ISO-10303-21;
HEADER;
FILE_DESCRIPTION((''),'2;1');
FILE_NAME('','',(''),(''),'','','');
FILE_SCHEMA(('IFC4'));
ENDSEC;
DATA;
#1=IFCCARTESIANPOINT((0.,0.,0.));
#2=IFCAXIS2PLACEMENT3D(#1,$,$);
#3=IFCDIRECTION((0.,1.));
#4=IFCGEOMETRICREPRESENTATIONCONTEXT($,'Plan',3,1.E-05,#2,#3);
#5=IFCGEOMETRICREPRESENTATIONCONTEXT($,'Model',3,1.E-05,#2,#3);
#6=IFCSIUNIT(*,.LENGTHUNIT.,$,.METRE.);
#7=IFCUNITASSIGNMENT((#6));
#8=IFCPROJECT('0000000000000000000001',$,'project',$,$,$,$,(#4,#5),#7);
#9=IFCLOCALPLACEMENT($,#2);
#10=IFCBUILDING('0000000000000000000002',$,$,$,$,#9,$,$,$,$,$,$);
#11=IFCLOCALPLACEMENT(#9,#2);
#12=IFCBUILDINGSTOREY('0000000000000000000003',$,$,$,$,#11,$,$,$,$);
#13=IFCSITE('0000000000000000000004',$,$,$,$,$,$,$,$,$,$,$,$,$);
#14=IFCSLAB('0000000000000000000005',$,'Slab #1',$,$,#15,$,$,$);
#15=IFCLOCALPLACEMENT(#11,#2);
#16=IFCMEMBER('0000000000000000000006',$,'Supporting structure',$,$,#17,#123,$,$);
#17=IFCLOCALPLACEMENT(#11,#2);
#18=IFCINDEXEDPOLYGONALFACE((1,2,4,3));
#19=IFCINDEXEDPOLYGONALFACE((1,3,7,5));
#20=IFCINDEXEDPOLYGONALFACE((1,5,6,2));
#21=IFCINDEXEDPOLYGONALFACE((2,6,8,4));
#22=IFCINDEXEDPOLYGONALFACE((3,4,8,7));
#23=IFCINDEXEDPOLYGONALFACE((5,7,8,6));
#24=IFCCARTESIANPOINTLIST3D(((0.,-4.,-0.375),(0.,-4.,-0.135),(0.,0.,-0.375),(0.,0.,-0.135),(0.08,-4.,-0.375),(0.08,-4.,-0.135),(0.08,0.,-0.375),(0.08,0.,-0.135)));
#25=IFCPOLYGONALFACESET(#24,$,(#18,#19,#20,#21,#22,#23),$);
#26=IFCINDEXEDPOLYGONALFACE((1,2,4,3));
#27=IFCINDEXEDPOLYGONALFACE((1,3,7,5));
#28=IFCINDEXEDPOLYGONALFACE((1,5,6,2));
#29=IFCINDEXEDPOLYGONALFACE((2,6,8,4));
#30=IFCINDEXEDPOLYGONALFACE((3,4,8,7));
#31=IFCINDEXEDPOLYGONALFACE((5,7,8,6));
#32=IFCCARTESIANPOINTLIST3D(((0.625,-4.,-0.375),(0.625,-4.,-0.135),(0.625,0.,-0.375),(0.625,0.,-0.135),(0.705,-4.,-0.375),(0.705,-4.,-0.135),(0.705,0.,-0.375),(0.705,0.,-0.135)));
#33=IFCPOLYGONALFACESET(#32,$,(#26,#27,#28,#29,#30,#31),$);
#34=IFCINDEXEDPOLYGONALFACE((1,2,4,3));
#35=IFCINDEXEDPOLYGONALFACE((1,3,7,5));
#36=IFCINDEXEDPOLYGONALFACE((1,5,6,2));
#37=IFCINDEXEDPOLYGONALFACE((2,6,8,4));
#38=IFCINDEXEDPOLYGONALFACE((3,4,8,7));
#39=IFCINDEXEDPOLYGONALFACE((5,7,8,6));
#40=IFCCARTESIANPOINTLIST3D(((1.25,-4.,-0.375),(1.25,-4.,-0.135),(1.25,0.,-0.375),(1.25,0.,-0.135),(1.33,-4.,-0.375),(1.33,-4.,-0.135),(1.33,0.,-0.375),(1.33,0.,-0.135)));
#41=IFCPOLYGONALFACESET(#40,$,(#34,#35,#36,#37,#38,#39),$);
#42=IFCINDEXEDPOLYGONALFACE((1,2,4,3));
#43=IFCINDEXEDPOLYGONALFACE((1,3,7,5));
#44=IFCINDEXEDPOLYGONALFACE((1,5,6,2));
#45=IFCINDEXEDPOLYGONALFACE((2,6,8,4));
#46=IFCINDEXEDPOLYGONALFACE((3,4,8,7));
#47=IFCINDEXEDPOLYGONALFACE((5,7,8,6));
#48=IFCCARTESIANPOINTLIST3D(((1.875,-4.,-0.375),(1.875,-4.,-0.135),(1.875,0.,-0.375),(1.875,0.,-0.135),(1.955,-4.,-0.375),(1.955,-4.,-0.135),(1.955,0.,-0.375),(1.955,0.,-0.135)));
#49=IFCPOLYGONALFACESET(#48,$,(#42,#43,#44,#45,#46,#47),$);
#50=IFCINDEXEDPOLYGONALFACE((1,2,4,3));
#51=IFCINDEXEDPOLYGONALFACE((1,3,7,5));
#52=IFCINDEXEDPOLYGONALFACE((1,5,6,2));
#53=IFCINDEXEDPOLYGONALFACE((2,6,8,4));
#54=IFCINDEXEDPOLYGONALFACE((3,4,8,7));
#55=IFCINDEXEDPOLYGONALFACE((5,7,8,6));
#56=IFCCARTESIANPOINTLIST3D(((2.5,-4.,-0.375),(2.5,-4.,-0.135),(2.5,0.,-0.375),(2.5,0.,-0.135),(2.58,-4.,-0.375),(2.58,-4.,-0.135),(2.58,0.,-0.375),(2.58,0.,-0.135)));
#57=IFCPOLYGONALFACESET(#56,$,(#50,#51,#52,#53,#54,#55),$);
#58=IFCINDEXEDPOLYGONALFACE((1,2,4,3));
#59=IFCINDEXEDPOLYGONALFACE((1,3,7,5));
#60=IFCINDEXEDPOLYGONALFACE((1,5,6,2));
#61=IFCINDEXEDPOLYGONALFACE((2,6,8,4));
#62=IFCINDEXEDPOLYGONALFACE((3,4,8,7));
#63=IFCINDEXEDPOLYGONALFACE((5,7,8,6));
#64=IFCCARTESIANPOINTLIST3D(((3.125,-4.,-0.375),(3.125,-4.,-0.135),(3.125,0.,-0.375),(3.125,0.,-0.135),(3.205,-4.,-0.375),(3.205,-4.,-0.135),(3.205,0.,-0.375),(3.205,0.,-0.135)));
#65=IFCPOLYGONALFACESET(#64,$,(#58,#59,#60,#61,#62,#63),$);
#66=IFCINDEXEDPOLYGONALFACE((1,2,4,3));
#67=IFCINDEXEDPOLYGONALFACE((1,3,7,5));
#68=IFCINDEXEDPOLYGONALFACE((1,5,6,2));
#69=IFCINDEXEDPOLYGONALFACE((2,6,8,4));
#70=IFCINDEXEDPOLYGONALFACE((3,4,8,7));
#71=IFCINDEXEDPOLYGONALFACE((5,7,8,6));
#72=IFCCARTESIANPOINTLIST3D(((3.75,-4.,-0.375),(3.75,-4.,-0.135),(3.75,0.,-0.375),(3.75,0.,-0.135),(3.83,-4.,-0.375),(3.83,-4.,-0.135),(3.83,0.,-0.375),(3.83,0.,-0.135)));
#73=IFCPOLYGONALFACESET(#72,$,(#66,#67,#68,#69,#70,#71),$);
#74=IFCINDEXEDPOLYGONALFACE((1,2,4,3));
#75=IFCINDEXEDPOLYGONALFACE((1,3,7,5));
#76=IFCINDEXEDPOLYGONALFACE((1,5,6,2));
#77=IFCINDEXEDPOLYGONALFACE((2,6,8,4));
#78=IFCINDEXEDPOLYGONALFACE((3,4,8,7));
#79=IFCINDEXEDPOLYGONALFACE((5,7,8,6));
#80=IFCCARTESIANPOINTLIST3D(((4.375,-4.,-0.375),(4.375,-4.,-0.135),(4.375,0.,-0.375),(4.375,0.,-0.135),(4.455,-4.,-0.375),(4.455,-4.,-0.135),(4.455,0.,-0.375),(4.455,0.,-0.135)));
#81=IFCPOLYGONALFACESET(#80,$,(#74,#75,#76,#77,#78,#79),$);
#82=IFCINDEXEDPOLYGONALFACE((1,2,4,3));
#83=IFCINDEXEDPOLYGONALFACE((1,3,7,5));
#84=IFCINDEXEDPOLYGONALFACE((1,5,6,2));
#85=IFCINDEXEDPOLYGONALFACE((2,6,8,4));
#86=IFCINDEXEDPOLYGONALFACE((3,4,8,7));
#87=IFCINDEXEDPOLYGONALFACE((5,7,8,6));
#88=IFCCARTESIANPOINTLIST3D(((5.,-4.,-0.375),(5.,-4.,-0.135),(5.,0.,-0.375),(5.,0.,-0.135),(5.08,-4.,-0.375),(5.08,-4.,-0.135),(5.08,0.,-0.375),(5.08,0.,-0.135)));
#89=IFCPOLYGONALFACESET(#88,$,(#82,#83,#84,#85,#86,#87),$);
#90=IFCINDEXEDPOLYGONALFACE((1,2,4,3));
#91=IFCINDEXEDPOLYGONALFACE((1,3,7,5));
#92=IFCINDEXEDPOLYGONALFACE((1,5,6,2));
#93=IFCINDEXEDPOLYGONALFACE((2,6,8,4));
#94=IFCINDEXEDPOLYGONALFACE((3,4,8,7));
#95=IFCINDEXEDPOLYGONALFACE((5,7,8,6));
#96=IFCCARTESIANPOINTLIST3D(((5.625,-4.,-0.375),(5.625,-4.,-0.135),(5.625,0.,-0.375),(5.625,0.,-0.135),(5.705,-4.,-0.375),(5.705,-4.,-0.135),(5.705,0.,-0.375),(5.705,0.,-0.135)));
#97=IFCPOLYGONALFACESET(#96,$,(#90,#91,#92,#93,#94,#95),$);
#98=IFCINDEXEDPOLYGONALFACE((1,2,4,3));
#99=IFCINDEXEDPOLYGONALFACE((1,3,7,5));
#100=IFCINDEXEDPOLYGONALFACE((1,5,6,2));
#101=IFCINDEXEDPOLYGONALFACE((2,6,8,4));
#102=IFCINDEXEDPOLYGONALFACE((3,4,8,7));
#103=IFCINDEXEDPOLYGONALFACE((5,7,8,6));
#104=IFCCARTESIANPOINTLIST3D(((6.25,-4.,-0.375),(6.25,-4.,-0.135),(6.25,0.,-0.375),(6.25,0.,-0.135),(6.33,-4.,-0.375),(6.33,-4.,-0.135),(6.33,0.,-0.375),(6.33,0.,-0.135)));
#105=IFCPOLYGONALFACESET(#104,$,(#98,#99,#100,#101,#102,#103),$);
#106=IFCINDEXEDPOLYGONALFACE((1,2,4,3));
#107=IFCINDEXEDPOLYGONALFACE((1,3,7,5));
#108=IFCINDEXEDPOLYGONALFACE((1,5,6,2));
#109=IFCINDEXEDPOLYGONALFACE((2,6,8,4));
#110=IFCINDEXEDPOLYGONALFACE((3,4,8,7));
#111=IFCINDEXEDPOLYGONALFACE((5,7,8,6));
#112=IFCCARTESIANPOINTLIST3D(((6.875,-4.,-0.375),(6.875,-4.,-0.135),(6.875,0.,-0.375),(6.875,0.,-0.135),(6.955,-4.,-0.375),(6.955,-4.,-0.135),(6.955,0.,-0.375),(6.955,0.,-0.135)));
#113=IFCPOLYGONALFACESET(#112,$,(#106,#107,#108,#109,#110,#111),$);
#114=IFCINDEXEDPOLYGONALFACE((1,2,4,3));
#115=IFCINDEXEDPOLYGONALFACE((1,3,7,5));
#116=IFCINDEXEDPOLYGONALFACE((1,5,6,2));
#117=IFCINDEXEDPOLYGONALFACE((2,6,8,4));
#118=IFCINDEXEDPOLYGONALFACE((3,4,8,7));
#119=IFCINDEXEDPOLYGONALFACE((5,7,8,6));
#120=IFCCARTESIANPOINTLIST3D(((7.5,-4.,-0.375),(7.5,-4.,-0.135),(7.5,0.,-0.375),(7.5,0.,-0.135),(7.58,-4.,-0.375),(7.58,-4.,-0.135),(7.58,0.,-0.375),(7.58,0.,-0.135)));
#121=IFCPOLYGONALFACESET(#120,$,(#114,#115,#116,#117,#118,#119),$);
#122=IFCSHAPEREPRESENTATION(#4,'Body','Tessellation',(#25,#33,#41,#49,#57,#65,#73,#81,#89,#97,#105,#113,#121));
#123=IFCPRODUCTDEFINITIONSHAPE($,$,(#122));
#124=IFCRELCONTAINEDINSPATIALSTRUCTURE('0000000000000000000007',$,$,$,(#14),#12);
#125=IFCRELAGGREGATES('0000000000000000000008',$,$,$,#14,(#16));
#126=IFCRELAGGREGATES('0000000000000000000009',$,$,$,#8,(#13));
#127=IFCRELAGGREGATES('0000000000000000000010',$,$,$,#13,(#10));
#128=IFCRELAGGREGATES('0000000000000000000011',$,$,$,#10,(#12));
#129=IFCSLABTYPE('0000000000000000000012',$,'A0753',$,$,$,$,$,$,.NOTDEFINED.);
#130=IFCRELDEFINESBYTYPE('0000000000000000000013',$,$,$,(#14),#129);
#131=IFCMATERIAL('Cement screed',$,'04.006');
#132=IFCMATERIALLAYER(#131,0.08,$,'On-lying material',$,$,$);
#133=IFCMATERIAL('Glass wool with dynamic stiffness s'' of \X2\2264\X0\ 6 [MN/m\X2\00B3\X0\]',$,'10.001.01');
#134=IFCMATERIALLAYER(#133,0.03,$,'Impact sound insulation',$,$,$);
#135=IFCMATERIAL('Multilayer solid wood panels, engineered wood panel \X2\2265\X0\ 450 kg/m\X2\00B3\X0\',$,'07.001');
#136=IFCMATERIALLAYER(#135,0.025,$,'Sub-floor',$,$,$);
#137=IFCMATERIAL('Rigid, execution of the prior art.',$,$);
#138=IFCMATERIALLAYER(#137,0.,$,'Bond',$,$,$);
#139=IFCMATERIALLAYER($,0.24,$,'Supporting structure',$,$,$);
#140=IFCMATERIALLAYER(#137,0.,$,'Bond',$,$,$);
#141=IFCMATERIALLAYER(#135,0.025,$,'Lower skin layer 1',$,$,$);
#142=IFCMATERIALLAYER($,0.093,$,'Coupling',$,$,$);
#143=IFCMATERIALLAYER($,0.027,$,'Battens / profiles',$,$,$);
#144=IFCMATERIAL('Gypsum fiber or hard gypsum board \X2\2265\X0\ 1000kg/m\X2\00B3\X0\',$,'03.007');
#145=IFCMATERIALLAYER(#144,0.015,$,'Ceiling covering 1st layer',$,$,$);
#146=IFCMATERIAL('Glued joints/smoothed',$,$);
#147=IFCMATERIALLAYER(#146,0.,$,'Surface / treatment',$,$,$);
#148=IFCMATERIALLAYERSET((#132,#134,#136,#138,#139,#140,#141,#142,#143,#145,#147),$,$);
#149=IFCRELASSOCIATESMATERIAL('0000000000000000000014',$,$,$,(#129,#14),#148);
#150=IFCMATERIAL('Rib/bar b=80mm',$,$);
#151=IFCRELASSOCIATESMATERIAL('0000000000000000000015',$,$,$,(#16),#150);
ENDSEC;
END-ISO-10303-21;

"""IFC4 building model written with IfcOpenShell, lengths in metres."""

from ifc_helpers import new_model, si_unit, direction, frame, frame_2d, origin, place, context, project, spatial, rectangle, extrude, material, layer, layer_set, type_object, element, aggregate, save


model = new_model("IFC4")

# Units and contexts
plan_context = context("Plan", 3, precision=1e-05, world=origin(), true_north=direction((0.0, 1.0)))
model_context = context("Model", 3, precision=1e-05, world=origin(), true_north=direction((0.0, 1.0)))
ifc_project = project(units=[si_unit("LENGTHUNIT", "METRE")], contexts=[plan_context, model_context])

# Site, building, storey
site = spatial("IfcSite", under=ifc_project)
building_placement = place(None, origin())
building = spatial("IfcBuilding", under=site, at=building_placement)
storey_placement = place(building_placement, origin())
storey = spatial("IfcBuildingStorey", under=building, at=storey_placement)

# Slab, member
ifc_material_1 = material(Name="Cement screed", Category="04.006")
ifc_layer_1 = layer(ifc_material_1, 0.08, Name="On-lying material")
ifc_material_2 = material(Name="Glass wool with dynamic stiffness s' of ≤ 6 [MN/m³]", Category="10.001.01")
ifc_layer_2 = layer(ifc_material_2, 0.03, Name="Impact sound insulation")
ifc_material_3 = material(Name="Multilayer solid wood panels, engineered wood panel ≥ 450 kg/m³", Category="07.001")
ifc_layer_3 = layer(ifc_material_3, 0.025, Name="Sub-floor")
ifc_material_4 = material(Name="Rigid, execution of the prior art.")
ifc_layer_4 = layer(ifc_material_4, 0.0, Name="Bond")
ifc_layer_5 = layer(None, 0.24, Name="Supporting structure")
ifc_layer_6 = layer(ifc_material_4, 0.0, Name="Bond")
ifc_layer_7 = layer(ifc_material_3, 0.025, Name="Lower skin layer 1")
ifc_layer_8 = layer(None, 0.093, Name="Coupling")
ifc_layer_9 = layer(None, 0.027, Name="Battens / profiles")
ifc_material_5 = material(Name="Gypsum fiber or hard gypsum board ≥ 1000kg/m³", Category="03.007")
ifc_layer_10 = layer(ifc_material_5, 0.015, Name="Ceiling covering 1st layer")
ifc_material_6 = material(Name="Glued joints/smoothed")
ifc_layer_11 = layer(ifc_material_6, 0.0, Name="Surface / treatment")
ifc_layer_set = layer_set([ifc_layer_1, ifc_layer_2, ifc_layer_3, ifc_layer_4, ifc_layer_5, ifc_layer_6, ifc_layer_7, ifc_layer_8, ifc_layer_9, ifc_layer_10, ifc_layer_11])
slab_type = type_object("IfcSlabType", Name="A0753", PredefinedType="NOTDEFINED", material=ifc_layer_set)
slab_placement = place(None, frame((0.0, 0.0, 0.0), z_axis=(0.0, 0.0, -1.0), x_axis=(1.0, 0.0, 0.0)))
slab = element("IfcSlab", 1, at=slab_placement, inside=storey, type_object=slab_type, material=ifc_layer_set, Name="Slab #1")
ifc_material_7 = material(Name="Rib/bar b=80mm")
member_1_placement = place(slab_placement, origin())
member_1 = element("IfcMember", 2, at=member_1_placement, material=ifc_material_7, Name="Supporting structure", context=plan_context, shape_type="SweptSolid", body=[
    extrude(rectangle(XDim=0.08, YDim=0.24, at=frame_2d((0.04, 0.12), x_axis=(1.0, 0.0))), frame((0.0, 4.0, 0.135), z_axis=(0.0, -1.0, 0.0), x_axis=(1.0, 0.0, 0.0)), (0.0, 0.0, 1.0), 4.0),
    extrude(rectangle(XDim=0.08, YDim=0.24, at=frame_2d((0.04, 0.12), x_axis=(1.0, 0.0))), frame((0.625, 4.0, 0.135), z_axis=(0.0, -1.0, 0.0), x_axis=(1.0, 0.0, 0.0)), (0.0, 0.0, 1.0), 4.0),
    extrude(rectangle(XDim=0.08, YDim=0.24, at=frame_2d((0.04, 0.12), x_axis=(1.0, 0.0))), frame((1.25, 4.0, 0.135), z_axis=(0.0, -1.0, 0.0), x_axis=(1.0, 0.0, 0.0)), (0.0, 0.0, 1.0), 4.0),
    extrude(rectangle(XDim=0.08, YDim=0.24, at=frame_2d((0.04, 0.12), x_axis=(1.0, 0.0))), frame((1.875, 4.0, 0.135), z_axis=(0.0, -1.0, 0.0), x_axis=(1.0, 0.0, 0.0)), (0.0, 0.0, 1.0), 4.0),
    extrude(rectangle(XDim=0.08, YDim=0.24, at=frame_2d((0.04, 0.12), x_axis=(1.0, 0.0))), frame((2.5, 4.0, 0.135), z_axis=(0.0, -1.0, 0.0), x_axis=(1.0, 0.0, 0.0)), (0.0, 0.0, 1.0), 4.0),
    extrude(rectangle(XDim=0.08, YDim=0.24, at=frame_2d((0.04, 0.12), x_axis=(1.0, 0.0))), frame((3.125, 4.0, 0.135), z_axis=(0.0, -1.0, 0.0), x_axis=(1.0, 0.0, 0.0)), (0.0, 0.0, 1.0), 4.0),
    extrude(rectangle(XDim=0.08, YDim=0.24, at=frame_2d((0.04, 0.12), x_axis=(1.0, 0.0))), frame((3.75, 4.0, 0.135), z_axis=(0.0, -1.0, 0.0), x_axis=(1.0, 0.0, 0.0)), (0.0, 0.0, 1.0), 4.0),
    extrude(rectangle(XDim=0.08, YDim=0.24, at=frame_2d((0.04, 0.12), x_axis=(1.0, 0.0))), frame((4.375, 4.0, 0.135), z_axis=(0.0, -1.0, 0.0), x_axis=(1.0, 0.0, 0.0)), (0.0, 0.0, 1.0), 4.0),
    extrude(rectangle(XDim=0.08, YDim=0.24, at=frame_2d((0.04, 0.12), x_axis=(1.0, 0.0))), frame((5.0, 4.0, 0.135), z_axis=(0.0, -1.0, 0.0), x_axis=(1.0, 0.0, 0.0)), (0.0, 0.0, 1.0), 4.0),
    extrude(rectangle(XDim=0.08, YDim=0.24, at=frame_2d((0.04, 0.12), x_axis=(1.0, 0.0))), frame((5.625, 4.0, 0.135), z_axis=(0.0, -1.0, 0.0), x_axis=(1.0, 0.0, 0.0)), (0.0, 0.0, 1.0), 4.0),
    extrude(rectangle(XDim=0.08, YDim=0.24, at=frame_2d((0.04, 0.12), x_axis=(1.0, 0.0))), frame((6.25, 4.0, 0.135), z_axis=(0.0, -1.0, 0.0), x_axis=(1.0, 0.0, 0.0)), (0.0, 0.0, 1.0), 4.0),
    extrude(rectangle(XDim=0.08, YDim=0.24, at=frame_2d((0.04, 0.12), x_axis=(1.0, 0.0))), frame((6.875, 4.0, 0.135), z_axis=(0.0, -1.0, 0.0), x_axis=(1.0, 0.0, 0.0)), (0.0, 0.0, 1.0), 4.0),
    extrude(rectangle(XDim=0.08, YDim=0.24, at=frame_2d((0.04, 0.12), x_axis=(1.0, 0.0))), frame((7.5, 4.0, 0.135), z_axis=(0.0, -1.0, 0.0), x_axis=(1.0, 0.0, 0.0)), (0.0, 0.0, 1.0), 4.0),
])
aggregate(slab, [member_1])

save(model, "model.ifc")
